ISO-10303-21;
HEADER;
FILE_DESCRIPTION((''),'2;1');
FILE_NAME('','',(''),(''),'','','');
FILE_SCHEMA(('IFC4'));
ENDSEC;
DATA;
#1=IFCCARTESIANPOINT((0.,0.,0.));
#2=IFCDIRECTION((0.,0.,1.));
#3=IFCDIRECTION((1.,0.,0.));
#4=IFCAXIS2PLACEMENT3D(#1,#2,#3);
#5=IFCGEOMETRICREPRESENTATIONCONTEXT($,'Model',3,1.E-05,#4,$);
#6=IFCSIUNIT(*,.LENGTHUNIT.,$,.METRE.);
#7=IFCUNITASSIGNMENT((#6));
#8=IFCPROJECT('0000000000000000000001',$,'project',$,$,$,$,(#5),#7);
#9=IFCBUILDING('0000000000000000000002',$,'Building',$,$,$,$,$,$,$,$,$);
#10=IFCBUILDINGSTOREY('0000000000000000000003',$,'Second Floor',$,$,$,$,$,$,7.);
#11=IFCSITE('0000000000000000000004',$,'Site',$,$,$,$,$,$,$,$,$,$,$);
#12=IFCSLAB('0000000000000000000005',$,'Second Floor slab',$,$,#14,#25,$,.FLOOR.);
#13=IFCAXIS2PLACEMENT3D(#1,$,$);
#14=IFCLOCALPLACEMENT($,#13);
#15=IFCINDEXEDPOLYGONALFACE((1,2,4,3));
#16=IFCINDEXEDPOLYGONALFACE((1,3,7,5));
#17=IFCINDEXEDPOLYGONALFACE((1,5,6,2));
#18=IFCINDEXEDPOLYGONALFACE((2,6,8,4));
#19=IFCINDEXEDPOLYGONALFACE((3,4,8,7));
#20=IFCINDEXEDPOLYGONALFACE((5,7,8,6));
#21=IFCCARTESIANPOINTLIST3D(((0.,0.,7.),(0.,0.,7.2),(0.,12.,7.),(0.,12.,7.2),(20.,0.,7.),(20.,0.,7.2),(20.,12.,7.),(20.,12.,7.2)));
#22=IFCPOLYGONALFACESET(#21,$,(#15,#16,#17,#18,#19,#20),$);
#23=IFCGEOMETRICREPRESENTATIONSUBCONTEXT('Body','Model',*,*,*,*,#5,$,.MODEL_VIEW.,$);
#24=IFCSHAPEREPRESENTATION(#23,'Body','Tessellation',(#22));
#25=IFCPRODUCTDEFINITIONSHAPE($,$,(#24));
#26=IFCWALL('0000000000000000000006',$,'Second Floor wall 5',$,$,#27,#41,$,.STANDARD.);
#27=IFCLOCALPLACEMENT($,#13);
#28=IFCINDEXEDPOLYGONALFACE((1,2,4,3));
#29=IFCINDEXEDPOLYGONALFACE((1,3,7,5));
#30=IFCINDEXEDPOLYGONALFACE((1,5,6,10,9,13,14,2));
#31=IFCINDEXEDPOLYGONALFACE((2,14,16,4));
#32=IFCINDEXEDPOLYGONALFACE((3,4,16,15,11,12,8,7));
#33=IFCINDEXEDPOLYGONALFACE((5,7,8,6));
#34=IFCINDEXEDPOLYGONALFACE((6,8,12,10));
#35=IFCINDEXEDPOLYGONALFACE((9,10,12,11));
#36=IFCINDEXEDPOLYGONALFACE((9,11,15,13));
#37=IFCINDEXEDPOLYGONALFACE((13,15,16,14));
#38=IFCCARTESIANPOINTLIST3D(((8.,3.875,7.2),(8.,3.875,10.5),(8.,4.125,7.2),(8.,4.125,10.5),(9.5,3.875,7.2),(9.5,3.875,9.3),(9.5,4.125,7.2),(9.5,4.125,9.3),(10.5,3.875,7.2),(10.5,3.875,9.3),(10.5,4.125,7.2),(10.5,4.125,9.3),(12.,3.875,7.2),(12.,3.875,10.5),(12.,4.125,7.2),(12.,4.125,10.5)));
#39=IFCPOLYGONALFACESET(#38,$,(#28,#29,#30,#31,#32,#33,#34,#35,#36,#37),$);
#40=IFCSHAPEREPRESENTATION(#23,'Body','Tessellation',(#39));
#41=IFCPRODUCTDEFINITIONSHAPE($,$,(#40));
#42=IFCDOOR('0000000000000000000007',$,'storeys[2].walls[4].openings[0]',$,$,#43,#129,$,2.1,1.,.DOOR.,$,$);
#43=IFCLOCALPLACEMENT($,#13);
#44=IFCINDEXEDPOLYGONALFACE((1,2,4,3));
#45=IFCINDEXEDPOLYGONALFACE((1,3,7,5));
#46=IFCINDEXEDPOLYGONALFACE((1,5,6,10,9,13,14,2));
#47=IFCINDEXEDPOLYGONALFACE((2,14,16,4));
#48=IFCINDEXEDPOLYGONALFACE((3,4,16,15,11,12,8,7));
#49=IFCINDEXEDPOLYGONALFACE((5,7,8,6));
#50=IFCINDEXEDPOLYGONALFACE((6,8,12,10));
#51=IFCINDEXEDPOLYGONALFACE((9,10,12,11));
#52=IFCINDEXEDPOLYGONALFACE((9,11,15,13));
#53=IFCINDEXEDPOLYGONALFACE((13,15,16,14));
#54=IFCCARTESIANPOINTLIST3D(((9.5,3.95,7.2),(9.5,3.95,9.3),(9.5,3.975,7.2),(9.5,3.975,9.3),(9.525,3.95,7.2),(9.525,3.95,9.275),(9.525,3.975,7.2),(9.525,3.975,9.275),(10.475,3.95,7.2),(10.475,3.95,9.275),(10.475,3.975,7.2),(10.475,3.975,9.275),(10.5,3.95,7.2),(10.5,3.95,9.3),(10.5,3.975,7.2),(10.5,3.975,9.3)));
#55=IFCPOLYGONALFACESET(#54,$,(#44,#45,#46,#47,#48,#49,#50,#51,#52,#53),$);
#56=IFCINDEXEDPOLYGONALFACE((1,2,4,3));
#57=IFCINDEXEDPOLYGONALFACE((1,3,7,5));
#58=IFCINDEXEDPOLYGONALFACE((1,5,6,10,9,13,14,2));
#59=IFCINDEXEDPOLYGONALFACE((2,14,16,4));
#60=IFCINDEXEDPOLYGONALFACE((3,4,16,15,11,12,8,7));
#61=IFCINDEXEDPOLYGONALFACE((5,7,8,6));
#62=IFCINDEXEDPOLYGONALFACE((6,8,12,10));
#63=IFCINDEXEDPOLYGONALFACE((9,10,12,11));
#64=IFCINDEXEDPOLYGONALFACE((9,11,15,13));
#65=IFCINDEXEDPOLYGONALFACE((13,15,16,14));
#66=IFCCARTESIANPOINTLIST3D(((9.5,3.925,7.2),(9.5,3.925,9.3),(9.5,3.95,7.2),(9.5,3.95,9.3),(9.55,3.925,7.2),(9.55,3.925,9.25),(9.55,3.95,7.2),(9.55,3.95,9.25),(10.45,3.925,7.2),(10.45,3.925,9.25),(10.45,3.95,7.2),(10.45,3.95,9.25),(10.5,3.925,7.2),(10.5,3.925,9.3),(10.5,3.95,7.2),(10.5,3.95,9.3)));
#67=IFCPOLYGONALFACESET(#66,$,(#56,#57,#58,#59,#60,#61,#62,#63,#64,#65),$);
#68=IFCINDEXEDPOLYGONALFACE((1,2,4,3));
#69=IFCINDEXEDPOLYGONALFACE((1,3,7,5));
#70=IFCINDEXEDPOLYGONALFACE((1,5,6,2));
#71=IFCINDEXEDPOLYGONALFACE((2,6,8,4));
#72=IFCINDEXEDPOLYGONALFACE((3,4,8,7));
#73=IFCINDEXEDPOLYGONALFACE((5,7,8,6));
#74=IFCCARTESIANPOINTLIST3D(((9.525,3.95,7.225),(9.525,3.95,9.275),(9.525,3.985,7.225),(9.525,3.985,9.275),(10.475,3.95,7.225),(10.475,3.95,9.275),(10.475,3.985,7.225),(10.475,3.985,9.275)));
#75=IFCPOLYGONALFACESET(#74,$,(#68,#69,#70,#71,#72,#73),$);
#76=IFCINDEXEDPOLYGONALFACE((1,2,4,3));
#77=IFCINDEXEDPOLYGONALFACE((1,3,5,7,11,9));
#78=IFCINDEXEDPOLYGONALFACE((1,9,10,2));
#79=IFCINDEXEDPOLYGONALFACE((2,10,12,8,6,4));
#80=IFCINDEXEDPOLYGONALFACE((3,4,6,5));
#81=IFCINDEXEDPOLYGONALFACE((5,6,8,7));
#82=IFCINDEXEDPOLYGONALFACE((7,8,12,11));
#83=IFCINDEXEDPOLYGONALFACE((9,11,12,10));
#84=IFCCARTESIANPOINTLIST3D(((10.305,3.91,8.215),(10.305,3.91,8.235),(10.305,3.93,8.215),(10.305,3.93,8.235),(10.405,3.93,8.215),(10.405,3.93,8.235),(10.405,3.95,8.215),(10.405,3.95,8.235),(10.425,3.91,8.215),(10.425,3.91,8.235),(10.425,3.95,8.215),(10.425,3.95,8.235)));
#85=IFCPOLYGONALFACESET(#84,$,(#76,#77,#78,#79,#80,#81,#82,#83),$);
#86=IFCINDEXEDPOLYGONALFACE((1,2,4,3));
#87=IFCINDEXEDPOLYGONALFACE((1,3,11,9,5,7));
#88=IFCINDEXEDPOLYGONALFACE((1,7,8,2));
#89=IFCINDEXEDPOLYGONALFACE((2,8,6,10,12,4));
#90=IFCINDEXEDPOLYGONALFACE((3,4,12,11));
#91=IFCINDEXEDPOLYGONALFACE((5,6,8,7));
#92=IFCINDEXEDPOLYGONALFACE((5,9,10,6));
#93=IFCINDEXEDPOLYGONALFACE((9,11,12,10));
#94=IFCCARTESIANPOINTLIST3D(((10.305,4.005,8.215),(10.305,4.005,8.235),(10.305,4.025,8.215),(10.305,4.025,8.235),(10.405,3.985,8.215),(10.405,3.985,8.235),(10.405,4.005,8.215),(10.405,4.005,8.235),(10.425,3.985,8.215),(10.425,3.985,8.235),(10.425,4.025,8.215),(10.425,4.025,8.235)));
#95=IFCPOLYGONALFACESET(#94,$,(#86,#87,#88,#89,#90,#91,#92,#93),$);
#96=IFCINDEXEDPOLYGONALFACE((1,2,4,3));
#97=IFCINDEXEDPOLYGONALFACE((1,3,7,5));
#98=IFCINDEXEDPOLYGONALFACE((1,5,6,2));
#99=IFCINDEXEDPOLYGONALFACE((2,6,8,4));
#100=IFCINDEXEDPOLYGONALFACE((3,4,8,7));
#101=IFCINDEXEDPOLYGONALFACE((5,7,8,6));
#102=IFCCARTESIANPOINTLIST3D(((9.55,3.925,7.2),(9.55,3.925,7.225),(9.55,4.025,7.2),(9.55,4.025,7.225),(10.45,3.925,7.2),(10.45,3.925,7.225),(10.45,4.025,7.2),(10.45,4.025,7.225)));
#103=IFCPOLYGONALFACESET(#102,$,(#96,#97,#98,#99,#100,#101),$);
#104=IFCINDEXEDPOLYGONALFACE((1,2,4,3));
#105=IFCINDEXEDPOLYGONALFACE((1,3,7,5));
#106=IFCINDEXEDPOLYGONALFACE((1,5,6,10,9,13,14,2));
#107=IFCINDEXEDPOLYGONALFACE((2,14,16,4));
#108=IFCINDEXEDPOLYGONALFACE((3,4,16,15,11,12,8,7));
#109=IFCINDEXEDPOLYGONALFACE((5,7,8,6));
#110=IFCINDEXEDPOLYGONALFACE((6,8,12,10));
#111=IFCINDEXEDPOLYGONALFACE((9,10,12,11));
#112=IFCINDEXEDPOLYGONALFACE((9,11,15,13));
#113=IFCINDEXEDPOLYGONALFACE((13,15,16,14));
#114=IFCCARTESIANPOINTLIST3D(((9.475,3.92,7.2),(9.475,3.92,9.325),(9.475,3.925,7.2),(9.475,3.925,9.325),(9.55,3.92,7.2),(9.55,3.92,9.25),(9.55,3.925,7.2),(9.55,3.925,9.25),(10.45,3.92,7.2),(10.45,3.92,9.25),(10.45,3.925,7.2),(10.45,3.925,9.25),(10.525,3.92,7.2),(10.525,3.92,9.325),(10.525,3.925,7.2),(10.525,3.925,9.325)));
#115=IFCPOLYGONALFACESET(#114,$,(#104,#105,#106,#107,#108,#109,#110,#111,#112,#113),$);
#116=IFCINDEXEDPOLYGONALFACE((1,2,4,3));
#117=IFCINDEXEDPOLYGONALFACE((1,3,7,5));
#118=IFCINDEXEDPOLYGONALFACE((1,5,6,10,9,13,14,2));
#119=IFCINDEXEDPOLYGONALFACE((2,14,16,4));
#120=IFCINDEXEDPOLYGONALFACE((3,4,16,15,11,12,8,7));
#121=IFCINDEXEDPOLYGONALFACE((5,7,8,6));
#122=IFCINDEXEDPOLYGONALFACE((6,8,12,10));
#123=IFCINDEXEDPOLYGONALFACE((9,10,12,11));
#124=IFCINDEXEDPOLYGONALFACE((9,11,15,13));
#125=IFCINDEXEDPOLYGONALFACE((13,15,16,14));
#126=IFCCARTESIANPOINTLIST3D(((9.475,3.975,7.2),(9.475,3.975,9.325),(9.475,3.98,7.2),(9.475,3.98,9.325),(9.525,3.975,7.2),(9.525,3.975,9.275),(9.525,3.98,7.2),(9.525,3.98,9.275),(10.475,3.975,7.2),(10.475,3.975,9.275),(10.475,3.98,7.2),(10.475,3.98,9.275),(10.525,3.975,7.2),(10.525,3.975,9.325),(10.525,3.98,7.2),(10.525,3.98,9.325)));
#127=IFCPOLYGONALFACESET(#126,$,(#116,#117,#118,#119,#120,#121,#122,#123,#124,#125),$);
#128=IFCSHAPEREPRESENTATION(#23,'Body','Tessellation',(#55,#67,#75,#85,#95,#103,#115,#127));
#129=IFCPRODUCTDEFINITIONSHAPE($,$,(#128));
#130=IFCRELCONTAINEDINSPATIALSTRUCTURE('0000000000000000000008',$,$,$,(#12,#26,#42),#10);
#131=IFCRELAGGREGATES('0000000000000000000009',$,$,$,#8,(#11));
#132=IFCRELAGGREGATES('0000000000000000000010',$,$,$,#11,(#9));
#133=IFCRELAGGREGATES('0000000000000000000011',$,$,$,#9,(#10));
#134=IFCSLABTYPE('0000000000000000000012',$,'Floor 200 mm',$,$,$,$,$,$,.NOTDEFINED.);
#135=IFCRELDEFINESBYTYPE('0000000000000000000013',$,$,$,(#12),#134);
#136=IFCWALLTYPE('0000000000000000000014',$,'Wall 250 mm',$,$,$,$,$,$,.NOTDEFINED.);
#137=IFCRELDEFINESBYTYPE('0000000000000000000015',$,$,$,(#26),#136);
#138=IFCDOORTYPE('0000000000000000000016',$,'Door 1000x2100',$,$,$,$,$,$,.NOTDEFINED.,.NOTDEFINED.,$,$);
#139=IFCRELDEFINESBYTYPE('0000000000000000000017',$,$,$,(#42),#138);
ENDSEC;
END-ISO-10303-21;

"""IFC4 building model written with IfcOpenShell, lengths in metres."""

from ifc_helpers import new_model, si_unit, frame, origin_with_axes, place, context, subcontext, project, spatial, line, indexed_curve, outline, extrude, type_object, element, fill, save


model = new_model("IFC4")

# Units and contexts
model_context = context("Model", 3, precision=1e-05, world=origin_with_axes())
body_context = subcontext(model_context, "Body", "Model", "MODEL_VIEW")
ifc_project = project(units=[si_unit("LENGTHUNIT", "METRE")], contexts=[model_context])

# Site, building, storey
site = spatial("IfcSite", under=ifc_project, Name="Site")
building = spatial("IfcBuilding", under=site, Name="Building")
storey = spatial("IfcBuildingStorey", under=building, Name="Second Floor", Elevation=7.0)

# Slab
slab_type = type_object("IfcSlabType", Name="Floor 200 mm", PredefinedType="NOTDEFINED")
slab_placement = place(None, frame((0.0, 0.0, 7.0), z_axis=(0.0, 0.0, 1.0), x_axis=(1.0, 0.0, 0.0)))
element("IfcSlab", 1, at=slab_placement, inside=storey, type_object=slab_type, Name="Second Floor slab", PredefinedType="FLOOR", context=body_context, shape_type="SweptSolid", body=[
    extrude(outline(indexed_curve([(0.0, 0.0), (20.0, 0.0), (20.0, 12.0), (0.0, 12.0)])), None, (0.0, 0.0, 1.0), 0.2),
])

# Wall, opening, door
wall_type_1 = type_object("IfcWallType", Name="Wall 250 mm", PredefinedType="NOTDEFINED")
wall_1_placement = place(None, frame((8.0, 4.0, 7.2), z_axis=(0.0, 0.0, 1.0), x_axis=(1.0, 0.0, 0.0)))
wall_1 = element("IfcWall", 2, at=wall_1_placement, inside=storey, type_object=wall_type_1, Name="Second Floor wall 5", PredefinedType="STANDARD", context=body_context, shape_type="SweptSolid", body=[
    extrude(outline(indexed_curve([(0.0, 0.0), (0.0, 0.25), (4.0, 0.25), (4.0, 0.0), (0.0, 0.0)], self_intersect=False)), frame((0.0, -0.125, 0.0), z_axis=(0.0, 0.0, 1.0), x_axis=(1.0, 0.0, 0.0)), (0.0, 0.0, 1.0), 3.3),
])
opening_1_placement = place(wall_1_placement, frame((1.5, -0.135, 0.0), z_axis=(0.0, 0.0, 1.0), x_axis=(1.0, 0.0, 0.0)))
opening_1 = element("IfcOpeningElement", 3, at=opening_1_placement, cuts=wall_1, context=body_context, shape_type="SweptSolid", body=[
    extrude(outline(indexed_curve([(0.0, 0.0), (0.0, 0.27), (1.0, 0.27), (1.0, 0.0), (0.0, 0.0)], self_intersect=False)), origin_with_axes(), (0.0, 0.0, 1.0), 2.1),
])
door_type = type_object("IfcDoorType", Name="Door 1000x2100", OperationType="NOTDEFINED", PredefinedType="NOTDEFINED")
door_placement = place(None, frame((9.5, 3.925, 7.2), z_axis=(0.0, 0.0, 1.0), x_axis=(1.0, 0.0, 0.0)))
door = element("IfcDoor", 4, at=door_placement, inside=storey, type_object=door_type, Name="storeys[2].walls[4].openings[0]", OverallHeight=2.1, OverallWidth=1.0, PredefinedType="DOOR", context=body_context, shape_type="SweptSolid", body=[
    extrude(outline(indexed_curve([(0.0, 0.0), (0.0, 2.1), (1.0, 2.1), (1.0, 0.0), (0.975, 0.0), (0.975, 2.075), (0.025, 2.075), (0.025, 0.0)], segments=[line(1, 2, 3, 4, 5, 6, 7, 8, 1)])), frame((0.0, 0.025, 0.0), z_axis=(0.0, -1.0, 0.0), x_axis=(1.0, 0.0, 0.0)), (0.0, 0.0, -1.0), 0.025),
    extrude(outline(indexed_curve([(0.0, 0.0), (0.0, 2.1), (1.0, 2.1), (1.0, 0.0), (0.95, 0.0), (0.95, 2.05), (0.05, 2.05), (0.05, 0.0)], segments=[line(1, 2, 3, 4, 5, 6, 7, 8, 1)])), frame((0.0, 0.0, 0.0), z_axis=(0.0, -1.0, 0.0), x_axis=(1.0, 0.0, 0.0)), (0.0, 0.0, -1.0), 0.025),
    extrude(outline(indexed_curve([(0.0, 0.0), (0.95, 0.0), (0.95, 0.035), (0.0, 0.035)], segments=[line(1, 2, 3, 4, 1)])), frame((0.025, 0.025, 0.025), z_axis=(0.0, 0.0, 1.0), x_axis=(1.0, 0.0, 0.0)), (0.0, 0.0, 1.0), 2.05),
    extrude(outline(indexed_curve([(0.0, 0.0), (0.0, -0.04), (-0.12, -0.04), (-0.12, -0.02), (-0.02, -0.02), (-0.02, 0.0)], segments=[line(1, 2, 3, 4, 5, 6, 1)])), frame((0.925, 0.025, 1.015), z_axis=(0.0, 0.0, 1.0), x_axis=(1.0, 0.0, 0.0)), (0.0, 0.0, 1.0), 0.02),
    extrude(outline(indexed_curve([(0.0, 0.0), (0.0, 0.04), (-0.12, 0.04), (-0.12, 0.02), (-0.02, 0.02), (-0.02, 0.0)], segments=[line(1, 2, 3, 4, 5, 6, 1)])), frame((0.925, 0.06, 1.015), z_axis=(0.0, 0.0, 1.0), x_axis=(1.0, 0.0, 0.0)), (0.0, 0.0, 1.0), 0.02),
    extrude(outline(indexed_curve([(0.0, 0.0), (0.9, 0.0), (0.9, 0.1), (0.0, 0.1)], segments=[line(1, 2, 3, 4, 1)])), frame((0.05, 0.0, 0.0), z_axis=(0.0, 0.0, 1.0), x_axis=(1.0, 0.0, 0.0)), (0.0, 0.0, 1.0), 0.025),
    extrude(outline(indexed_curve([(0.0, 0.0), (0.0, 2.125), (1.05, 2.125), (1.05, 0.0), (0.975, 0.0), (0.975, 2.05), (0.075, 2.05), (0.075, 0.0)], segments=[line(1, 2, 3, 4, 5, 6, 7, 8, 1)])), frame((-0.025, -0.005, 0.0), z_axis=(0.0, -1.0, 0.0), x_axis=(1.0, 0.0, 0.0)), (0.0, 0.0, -1.0), 0.005),
    extrude(outline(indexed_curve([(0.0, 0.0), (0.0, 2.125), (1.05, 2.125), (1.05, 0.0), (1.0, 0.0), (1.0, 2.075), (0.05, 2.075), (0.05, 0.0)], segments=[line(1, 2, 3, 4, 5, 6, 7, 8, 1)])), frame((-0.025, 0.05, 0.0), z_axis=(0.0, -1.0, 0.0), x_axis=(1.0, 0.0, 0.0)), (0.0, 0.0, -1.0), 0.005),
])
fill(opening_1, door)

save(model, "model.ifc")
